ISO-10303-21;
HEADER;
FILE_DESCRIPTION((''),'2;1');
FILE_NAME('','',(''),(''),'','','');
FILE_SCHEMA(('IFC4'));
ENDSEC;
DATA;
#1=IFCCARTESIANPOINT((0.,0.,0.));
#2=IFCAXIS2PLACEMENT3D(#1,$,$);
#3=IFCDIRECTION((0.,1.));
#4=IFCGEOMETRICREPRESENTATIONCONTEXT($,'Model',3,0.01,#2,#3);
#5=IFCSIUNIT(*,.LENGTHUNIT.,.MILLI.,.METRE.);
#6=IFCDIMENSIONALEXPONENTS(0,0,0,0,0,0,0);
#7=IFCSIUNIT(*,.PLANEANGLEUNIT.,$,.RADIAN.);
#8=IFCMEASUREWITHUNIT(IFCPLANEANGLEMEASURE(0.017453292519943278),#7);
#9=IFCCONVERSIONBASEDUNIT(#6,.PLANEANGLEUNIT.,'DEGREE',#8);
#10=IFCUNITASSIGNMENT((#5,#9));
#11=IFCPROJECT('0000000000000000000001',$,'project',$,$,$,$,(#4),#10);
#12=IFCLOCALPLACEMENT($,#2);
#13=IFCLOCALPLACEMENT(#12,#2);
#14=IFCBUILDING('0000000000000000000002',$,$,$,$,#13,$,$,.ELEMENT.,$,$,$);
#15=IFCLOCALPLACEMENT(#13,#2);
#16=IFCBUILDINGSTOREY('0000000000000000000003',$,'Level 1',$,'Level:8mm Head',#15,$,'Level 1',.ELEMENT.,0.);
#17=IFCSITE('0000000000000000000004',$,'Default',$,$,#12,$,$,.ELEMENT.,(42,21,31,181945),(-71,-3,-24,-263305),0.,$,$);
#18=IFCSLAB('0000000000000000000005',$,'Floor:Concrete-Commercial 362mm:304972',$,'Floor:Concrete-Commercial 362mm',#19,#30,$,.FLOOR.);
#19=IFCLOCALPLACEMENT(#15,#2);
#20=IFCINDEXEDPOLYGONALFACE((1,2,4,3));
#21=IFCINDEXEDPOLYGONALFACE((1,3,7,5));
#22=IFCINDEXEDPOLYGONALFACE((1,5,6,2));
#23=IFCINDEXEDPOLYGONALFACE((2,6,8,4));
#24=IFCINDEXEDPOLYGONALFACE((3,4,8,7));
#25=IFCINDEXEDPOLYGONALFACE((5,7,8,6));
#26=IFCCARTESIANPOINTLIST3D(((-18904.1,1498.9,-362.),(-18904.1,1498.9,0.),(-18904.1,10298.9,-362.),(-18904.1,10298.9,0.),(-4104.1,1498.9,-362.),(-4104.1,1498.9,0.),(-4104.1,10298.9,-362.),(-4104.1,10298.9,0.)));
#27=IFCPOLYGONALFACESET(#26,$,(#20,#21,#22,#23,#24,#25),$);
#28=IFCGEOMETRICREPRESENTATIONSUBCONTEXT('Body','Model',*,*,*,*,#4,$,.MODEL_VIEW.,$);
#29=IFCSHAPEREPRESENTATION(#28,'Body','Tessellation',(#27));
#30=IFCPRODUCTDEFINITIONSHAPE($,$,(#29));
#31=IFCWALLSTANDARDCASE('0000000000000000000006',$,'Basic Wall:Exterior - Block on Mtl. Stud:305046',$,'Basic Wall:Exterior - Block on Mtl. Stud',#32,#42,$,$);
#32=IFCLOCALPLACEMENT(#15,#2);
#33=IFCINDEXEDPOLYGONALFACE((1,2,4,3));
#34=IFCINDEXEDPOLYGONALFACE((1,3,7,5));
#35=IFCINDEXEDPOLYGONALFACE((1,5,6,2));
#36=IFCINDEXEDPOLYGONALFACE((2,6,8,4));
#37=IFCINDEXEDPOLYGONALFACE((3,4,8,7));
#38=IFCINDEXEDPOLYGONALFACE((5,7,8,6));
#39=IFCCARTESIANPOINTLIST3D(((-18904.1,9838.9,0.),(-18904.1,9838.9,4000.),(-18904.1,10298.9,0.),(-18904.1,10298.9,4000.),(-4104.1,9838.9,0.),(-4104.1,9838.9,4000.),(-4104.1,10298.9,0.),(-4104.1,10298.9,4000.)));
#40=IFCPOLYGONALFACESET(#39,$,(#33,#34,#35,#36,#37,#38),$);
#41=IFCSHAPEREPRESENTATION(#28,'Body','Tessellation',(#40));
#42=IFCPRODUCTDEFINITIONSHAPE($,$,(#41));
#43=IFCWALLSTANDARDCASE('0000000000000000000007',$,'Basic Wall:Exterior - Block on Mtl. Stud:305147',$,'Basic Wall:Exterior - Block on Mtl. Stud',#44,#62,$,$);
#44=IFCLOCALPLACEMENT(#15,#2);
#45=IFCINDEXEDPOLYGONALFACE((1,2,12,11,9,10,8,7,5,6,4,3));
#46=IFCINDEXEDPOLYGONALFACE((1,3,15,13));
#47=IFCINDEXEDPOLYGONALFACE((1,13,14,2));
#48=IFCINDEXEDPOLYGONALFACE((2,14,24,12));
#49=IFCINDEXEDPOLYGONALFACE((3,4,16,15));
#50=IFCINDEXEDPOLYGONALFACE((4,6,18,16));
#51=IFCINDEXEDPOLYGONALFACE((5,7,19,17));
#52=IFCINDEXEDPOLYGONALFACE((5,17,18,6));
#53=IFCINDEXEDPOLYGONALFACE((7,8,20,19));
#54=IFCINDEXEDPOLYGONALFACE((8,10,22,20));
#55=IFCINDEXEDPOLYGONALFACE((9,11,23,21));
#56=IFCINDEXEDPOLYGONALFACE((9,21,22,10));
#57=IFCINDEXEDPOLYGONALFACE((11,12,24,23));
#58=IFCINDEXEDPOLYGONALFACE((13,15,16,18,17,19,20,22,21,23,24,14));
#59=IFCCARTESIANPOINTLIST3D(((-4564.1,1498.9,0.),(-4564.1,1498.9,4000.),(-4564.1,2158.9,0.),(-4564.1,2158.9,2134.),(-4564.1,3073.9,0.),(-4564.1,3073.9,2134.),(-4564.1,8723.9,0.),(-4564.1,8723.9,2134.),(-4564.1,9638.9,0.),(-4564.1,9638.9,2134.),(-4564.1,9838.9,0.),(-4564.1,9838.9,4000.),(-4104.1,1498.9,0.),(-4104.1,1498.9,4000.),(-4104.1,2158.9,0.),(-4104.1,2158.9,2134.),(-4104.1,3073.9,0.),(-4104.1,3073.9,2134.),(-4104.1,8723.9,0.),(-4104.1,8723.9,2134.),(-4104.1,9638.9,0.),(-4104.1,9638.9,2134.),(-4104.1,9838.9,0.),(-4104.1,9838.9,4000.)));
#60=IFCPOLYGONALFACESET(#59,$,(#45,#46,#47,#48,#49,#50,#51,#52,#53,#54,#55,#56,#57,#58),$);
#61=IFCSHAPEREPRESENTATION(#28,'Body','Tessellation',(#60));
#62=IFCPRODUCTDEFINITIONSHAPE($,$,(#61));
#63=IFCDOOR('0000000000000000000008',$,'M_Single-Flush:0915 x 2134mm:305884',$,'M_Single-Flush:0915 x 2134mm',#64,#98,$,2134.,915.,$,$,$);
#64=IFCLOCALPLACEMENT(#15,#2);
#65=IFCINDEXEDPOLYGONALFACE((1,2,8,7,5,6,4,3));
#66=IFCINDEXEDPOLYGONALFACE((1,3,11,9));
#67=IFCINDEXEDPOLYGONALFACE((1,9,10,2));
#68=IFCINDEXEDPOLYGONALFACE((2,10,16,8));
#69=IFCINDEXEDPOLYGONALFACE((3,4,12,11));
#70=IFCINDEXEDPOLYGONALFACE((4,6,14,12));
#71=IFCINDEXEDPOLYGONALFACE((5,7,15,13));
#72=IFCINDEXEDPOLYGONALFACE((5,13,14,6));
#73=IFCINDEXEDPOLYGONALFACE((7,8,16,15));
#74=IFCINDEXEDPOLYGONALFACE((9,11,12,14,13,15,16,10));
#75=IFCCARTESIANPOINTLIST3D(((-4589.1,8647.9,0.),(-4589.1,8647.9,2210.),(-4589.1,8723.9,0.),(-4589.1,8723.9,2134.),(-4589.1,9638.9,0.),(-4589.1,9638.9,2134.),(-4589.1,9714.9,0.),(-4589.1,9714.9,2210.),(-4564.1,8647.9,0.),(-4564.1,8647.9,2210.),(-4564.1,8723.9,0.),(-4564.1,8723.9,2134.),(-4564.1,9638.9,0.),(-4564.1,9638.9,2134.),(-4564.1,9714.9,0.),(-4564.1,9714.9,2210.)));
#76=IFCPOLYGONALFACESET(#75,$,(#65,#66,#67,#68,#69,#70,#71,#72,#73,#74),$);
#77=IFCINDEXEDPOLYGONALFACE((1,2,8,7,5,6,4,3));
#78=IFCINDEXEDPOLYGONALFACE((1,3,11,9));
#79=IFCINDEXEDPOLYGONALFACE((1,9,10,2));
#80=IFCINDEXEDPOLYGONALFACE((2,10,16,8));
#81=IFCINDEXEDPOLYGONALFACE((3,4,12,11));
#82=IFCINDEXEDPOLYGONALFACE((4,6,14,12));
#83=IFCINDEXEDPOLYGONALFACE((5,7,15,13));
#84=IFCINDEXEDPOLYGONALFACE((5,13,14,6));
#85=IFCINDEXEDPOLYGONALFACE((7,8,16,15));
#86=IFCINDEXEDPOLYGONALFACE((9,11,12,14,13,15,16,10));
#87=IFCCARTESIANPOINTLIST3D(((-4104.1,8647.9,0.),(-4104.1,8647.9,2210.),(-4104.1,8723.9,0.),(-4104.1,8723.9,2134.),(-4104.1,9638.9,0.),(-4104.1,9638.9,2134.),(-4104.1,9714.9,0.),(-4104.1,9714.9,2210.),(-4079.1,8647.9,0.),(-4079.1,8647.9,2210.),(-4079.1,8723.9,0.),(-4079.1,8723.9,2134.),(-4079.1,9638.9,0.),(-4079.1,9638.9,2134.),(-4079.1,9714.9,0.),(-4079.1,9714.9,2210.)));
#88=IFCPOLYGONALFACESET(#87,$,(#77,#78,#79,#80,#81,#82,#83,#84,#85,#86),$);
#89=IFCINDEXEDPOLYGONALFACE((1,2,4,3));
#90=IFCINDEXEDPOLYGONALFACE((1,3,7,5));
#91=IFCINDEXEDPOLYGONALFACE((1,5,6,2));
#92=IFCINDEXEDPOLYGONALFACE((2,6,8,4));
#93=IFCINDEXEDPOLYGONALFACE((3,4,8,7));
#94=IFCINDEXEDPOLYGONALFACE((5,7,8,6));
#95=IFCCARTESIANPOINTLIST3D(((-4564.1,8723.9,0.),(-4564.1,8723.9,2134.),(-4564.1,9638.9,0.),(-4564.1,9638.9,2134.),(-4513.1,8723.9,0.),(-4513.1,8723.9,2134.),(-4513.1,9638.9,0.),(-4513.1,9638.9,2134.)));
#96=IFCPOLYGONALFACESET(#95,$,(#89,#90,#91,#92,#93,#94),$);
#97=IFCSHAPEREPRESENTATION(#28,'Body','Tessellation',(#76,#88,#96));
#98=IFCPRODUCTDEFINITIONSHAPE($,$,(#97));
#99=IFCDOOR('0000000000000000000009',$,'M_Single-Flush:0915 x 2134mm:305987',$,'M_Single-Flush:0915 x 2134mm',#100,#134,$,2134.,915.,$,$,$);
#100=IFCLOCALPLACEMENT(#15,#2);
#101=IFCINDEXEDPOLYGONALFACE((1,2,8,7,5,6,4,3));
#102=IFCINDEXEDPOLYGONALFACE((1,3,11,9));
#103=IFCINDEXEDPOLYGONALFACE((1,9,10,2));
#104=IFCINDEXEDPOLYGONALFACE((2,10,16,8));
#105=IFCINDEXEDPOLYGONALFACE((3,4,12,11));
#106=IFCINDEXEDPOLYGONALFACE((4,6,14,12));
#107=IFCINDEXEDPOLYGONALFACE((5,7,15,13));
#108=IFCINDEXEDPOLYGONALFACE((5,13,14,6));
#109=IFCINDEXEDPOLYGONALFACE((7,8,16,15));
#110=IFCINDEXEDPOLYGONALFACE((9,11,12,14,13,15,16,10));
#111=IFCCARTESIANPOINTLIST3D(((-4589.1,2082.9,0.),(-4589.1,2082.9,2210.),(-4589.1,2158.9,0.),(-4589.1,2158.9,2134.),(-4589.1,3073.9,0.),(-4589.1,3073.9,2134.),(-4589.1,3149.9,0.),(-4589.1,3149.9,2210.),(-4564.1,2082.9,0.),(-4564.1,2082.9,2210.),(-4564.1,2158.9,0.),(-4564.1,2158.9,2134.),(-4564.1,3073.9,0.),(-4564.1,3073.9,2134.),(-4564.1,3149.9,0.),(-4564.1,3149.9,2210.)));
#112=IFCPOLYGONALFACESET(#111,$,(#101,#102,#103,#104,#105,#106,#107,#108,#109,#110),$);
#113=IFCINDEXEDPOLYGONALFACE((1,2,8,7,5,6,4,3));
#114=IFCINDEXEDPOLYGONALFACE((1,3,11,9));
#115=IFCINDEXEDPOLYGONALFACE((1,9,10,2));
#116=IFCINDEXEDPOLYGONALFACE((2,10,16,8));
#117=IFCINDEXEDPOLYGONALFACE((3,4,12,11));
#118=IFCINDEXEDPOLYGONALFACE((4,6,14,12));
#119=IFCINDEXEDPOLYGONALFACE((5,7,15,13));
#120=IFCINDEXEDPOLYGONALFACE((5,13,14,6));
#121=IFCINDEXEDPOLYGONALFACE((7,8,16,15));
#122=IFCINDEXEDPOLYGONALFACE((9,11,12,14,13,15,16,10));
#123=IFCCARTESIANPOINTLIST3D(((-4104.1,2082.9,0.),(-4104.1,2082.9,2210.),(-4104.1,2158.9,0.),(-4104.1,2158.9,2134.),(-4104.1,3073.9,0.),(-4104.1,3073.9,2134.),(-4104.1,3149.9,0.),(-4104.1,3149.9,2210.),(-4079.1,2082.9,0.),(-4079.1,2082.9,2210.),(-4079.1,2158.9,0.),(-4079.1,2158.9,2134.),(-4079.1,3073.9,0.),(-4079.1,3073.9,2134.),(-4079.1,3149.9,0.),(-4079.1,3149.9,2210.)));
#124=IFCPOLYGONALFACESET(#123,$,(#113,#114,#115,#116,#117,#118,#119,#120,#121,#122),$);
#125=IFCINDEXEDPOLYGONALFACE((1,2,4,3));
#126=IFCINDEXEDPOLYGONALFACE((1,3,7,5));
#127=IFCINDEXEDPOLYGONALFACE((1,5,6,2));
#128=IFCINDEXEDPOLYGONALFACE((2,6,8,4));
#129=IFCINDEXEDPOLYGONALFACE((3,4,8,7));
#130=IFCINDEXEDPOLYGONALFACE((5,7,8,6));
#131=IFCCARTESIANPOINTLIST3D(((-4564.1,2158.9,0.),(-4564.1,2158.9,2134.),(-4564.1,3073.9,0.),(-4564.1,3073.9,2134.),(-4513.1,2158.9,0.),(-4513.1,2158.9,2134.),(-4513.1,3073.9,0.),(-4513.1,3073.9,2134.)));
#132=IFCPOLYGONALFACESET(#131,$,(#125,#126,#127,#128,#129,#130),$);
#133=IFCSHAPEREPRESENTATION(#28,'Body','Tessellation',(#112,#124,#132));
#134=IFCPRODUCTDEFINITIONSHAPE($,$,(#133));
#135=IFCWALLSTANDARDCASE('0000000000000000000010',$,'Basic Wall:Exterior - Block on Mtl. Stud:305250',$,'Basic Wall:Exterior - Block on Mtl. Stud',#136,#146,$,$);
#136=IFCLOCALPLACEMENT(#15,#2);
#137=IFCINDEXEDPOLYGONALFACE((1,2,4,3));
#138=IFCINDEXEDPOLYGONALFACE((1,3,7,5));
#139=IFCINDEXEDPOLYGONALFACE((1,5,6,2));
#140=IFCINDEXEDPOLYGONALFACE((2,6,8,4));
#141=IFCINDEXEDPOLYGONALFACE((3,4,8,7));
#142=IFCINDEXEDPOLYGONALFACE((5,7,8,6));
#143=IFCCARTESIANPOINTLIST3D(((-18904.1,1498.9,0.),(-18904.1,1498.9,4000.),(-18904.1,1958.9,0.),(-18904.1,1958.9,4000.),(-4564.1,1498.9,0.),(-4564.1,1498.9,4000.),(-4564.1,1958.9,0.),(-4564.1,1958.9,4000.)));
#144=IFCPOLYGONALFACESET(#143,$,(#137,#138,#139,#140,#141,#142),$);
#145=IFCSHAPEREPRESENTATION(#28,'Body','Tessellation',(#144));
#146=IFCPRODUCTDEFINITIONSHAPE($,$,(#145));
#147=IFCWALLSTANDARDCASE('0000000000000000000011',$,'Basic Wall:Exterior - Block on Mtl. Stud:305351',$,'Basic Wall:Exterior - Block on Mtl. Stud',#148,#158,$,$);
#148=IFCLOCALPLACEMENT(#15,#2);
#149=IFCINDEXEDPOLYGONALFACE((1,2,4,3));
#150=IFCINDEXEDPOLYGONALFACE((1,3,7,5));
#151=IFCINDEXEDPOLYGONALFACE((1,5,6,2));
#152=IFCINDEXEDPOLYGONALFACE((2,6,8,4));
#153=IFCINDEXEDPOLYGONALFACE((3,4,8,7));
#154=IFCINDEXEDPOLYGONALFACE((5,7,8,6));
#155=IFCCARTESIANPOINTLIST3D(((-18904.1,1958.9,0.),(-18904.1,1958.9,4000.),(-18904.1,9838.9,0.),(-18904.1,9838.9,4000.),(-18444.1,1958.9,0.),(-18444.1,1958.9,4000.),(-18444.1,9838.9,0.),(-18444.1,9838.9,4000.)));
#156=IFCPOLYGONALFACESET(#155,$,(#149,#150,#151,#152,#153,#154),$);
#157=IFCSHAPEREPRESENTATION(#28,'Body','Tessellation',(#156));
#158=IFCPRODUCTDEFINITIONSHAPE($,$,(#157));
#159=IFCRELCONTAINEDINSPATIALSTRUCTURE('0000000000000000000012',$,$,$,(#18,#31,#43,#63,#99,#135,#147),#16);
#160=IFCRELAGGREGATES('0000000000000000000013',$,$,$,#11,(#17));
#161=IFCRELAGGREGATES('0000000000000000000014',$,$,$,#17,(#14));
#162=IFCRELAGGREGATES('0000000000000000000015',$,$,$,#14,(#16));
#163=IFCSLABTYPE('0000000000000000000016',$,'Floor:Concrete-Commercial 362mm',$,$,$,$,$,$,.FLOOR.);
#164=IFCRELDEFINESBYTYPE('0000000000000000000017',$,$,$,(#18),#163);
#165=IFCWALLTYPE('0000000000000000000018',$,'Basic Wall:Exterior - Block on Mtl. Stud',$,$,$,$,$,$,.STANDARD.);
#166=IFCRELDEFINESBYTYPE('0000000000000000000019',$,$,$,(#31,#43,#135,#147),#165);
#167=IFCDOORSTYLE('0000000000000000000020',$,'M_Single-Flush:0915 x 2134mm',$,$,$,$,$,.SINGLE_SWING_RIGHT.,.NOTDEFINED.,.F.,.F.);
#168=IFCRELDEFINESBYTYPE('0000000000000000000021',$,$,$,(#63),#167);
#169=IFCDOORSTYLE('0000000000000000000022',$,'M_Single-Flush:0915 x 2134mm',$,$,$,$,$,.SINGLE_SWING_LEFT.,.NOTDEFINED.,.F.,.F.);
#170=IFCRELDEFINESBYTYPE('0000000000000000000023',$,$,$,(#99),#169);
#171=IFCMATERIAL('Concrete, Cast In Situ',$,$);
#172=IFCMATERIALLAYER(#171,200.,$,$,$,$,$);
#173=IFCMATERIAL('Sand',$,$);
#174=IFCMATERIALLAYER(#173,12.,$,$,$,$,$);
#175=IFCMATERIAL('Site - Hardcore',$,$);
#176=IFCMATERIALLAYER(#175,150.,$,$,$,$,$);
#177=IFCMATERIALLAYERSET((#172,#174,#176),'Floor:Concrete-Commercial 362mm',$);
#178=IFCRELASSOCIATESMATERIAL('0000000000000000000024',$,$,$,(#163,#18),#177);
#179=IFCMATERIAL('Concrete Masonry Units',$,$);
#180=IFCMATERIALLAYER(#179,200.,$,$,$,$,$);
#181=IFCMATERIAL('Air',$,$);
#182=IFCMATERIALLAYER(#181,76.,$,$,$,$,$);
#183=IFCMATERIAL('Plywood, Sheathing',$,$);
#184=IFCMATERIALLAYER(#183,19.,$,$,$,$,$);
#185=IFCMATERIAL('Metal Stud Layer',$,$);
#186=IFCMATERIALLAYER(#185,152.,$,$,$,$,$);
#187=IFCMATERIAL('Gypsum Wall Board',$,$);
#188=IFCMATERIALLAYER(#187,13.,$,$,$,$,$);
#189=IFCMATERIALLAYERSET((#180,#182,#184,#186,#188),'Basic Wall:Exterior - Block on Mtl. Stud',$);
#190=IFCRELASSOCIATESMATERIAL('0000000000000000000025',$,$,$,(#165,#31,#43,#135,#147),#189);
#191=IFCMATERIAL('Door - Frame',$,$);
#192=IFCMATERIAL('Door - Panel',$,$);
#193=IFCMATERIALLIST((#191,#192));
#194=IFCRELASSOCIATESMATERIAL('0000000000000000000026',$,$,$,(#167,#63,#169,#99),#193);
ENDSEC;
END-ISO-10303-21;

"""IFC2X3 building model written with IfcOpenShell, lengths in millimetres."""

from ifc_helpers import new_model, entity, si_unit, converted_unit, direction, frame, frame_2d, origin, place, context, subcontext, project, spatial, polyline, rectangle, outline, extrude, source, transform, mapped, material, material_list, layer, layer_set, layer_usage, type_object, type_shapes, element, fill, save


model = new_model("IFC2X3")

# Units and contexts
model_context = context("Model", 3, precision=0.01, world=origin(), true_north=direction((0.0, 1.0)))
body_context = subcontext(model_context, "Body", "Model", "MODEL_VIEW")
ifc_project = project(units=[si_unit("LENGTHUNIT", "METRE", prefix="MILLI"), converted_unit("PLANEANGLEUNIT", "DEGREE", entity("IfcPlaneAngleMeasure", 0.017453292519943278), si_unit("PLANEANGLEUNIT", "RADIAN"), dimensions=[0, 0, 0, 0, 0, 0, 0])], contexts=[model_context])

# Site, building, storey
site_placement = place(None, origin())
site = spatial("IfcSite", under=ifc_project, at=site_placement, Name="Default", CompositionType="ELEMENT", RefLatitude=(42, 21, 31, 181945), RefLongitude=(-71, -3, -24, -263305), RefElevation=0.0)
building_placement = place(site_placement, origin())
building = spatial("IfcBuilding", under=site, at=building_placement, CompositionType="ELEMENT")
storey_placement = place(building_placement, origin())
storey = spatial("IfcBuildingStorey", under=building, at=storey_placement, Name="Level 1", ObjectType="Level:8mm Head", LongName="Level 1", CompositionType="ELEMENT", Elevation=0.0)

# Slab
ifc_material_1 = material(Name="Concrete, Cast In Situ")
ifc_layer_1 = layer(ifc_material_1, 200.0)
ifc_material_2 = material(Name="Sand")
ifc_layer_2 = layer(ifc_material_2, 12.0)
ifc_material_3 = material(Name="Site - Hardcore")
ifc_layer_3 = layer(ifc_material_3, 150.0)
ifc_layer_set_1 = layer_set([ifc_layer_1, ifc_layer_2, ifc_layer_3], Name="Floor:Concrete-Commercial 362mm")
ifc_layer_usage_1 = layer_usage(ifc_layer_set_1, "AXIS3", "POSITIVE", 0.0)
slab_type = type_object("IfcSlabType", Name="Floor:Concrete-Commercial 362mm", PredefinedType="FLOOR", material=ifc_layer_set_1)
slab_placement = place(storey_placement, origin())
element("IfcSlab", 1, at=slab_placement, inside=storey, type_object=slab_type, material=ifc_layer_usage_1, Name="Floor:Concrete-Commercial 362mm:304972", ObjectType="Floor:Concrete-Commercial 362mm", PredefinedType="FLOOR", context=body_context, shape_type="SweptSolid", body=[
    extrude(rectangle(XDim=8800.0, YDim=14800.0, at=frame_2d((0.0, 0.0), x_axis=(1.0, 0.0))), frame((-11504.1, 5898.9, 0.0), z_axis=(0.0, 0.0, -1.0), x_axis=(0.0, 1.0, 0.0)), (0.0, 0.0, 1.0), 362.0),
])

# Wall
ifc_material_4 = material(Name="Concrete Masonry Units")
ifc_layer_4 = layer(ifc_material_4, 200.0)
ifc_material_5 = material(Name="Air")
ifc_layer_5 = layer(ifc_material_5, 76.0)
ifc_material_6 = material(Name="Plywood, Sheathing")
ifc_layer_6 = layer(ifc_material_6, 19.0)
ifc_material_7 = material(Name="Metal Stud Layer")
ifc_layer_7 = layer(ifc_material_7, 152.0)
ifc_material_8 = material(Name="Gypsum Wall Board")
ifc_layer_8 = layer(ifc_material_8, 13.0)
ifc_layer_set_2 = layer_set([ifc_layer_4, ifc_layer_5, ifc_layer_6, ifc_layer_7, ifc_layer_8], Name="Basic Wall:Exterior - Block on Mtl. Stud")
ifc_layer_usage_2 = layer_usage(ifc_layer_set_2, "AXIS2", "NEGATIVE", 230.0)
wall_type_1 = type_object("IfcWallType", Name="Basic Wall:Exterior - Block on Mtl. Stud", PredefinedType="STANDARD", material=ifc_layer_set_2)
wall_1_placement = place(storey_placement, frame((-18904.1, 10068.9, 0.0)))
element("IfcWallStandardCase", 2, at=wall_1_placement, inside=storey, type_object=wall_type_1, material=ifc_layer_usage_2, Name="Basic Wall:Exterior - Block on Mtl. Stud:305046", ObjectType="Basic Wall:Exterior - Block on Mtl. Stud", context=body_context, shape_type="SweptSolid", body=[
    extrude(rectangle(XDim=14800.0, YDim=460.0, at=frame_2d((7400.0, 0.0), x_axis=(-1.0, 0.0))), origin(), (0.0, 0.0, 1.0), 4000.0),
])

# Wall, openings, doors
wall_2_placement = place(storey_placement, frame((-4334.1, 9838.9, 0.0), z_axis=(0.0, 0.0, 1.0), x_axis=(0.0, -1.0, 0.0)))
wall_2 = element("IfcWallStandardCase", 3, at=wall_2_placement, inside=storey, type_object=wall_type_1, material=ifc_layer_usage_2, Name="Basic Wall:Exterior - Block on Mtl. Stud:305147", ObjectType="Basic Wall:Exterior - Block on Mtl. Stud", context=body_context, shape_type="SweptSolid", body=[
    extrude(rectangle(XDim=8340.0, YDim=460.0, at=frame_2d((4170.0, 0.0), x_axis=(-1.0, 0.0))), origin(), (0.0, 0.0, 1.0), 4000.0),
])
opening_1_placement = place(wall_2_placement, frame((1115.0, 230.0, 0.0)))
opening_1 = element("IfcOpeningElement", 4, at=opening_1_placement, cuts=wall_2, ObjectType="Opening", context=body_context, shape_type="SweptSolid", body=[
    extrude(rectangle(XDim=915.0, YDim=2134.0, at=frame_2d((1067.0, 457.5), x_axis=(0.0, 1.0))), frame((0.0, 0.0, 0.0), z_axis=(0.0, -1.0, 0.0), x_axis=(0.0, 0.0, 1.0)), (0.0, 0.0, 1.0), 460.0),
])
opening_2_placement = place(wall_2_placement, frame((7680.0, 230.0, 0.0)))
opening_2 = element("IfcOpeningElement", 5, at=opening_2_placement, cuts=wall_2, ObjectType="Opening", context=body_context, shape_type="SweptSolid", body=[
    extrude(rectangle(XDim=915.0, YDim=2134.0, at=frame_2d((1067.0, 457.5), x_axis=(0.0, -1.0))), frame((0.0, 0.0, 0.0), z_axis=(0.0, -1.0, 0.0), x_axis=(0.0, 0.0, 1.0)), (0.0, 0.0, 1.0), 460.0),
])
ifc_material_9 = material(Name="Door - Frame")
ifc_material_10 = material(Name="Door - Panel")
ifc_material_list = material_list([ifc_material_9, ifc_material_10])
door_style_1 = type_object("IfcDoorStyle", Name="M_Single-Flush:0915 x 2134mm", ConstructionType="NOTDEFINED", OperationType="SINGLE_SWING_RIGHT", ParameterTakesPrecedence=False, Sizeable=False, material=ifc_material_list)
shared_shape_1 = source(origin(), body_context, "Body", "SweptSolid", [
    extrude(outline(polyline([(-533.5, -1124.0), (533.5, -1124.0), (533.5, 1086.0), (457.5, 1086.0), (457.5, -1048.0), (-457.5, -1048.0), (-457.5, 1086.0), (-533.5, 1086.0), (-533.5, -1124.0)])), frame((457.5, 460.0, 1086.0), z_axis=(0.0, 1.0, 0.0), x_axis=(1.0, 0.0, 0.0)), (0.0, 0.0, 1.0), 25.0),
    extrude(outline(polyline([(-1124.0, -533.5), (1086.0, -533.5), (1086.0, -457.5), (-1048.0, -457.5), (-1048.0, 457.5), (1086.0, 457.5), (1086.0, 533.5), (-1124.0, 533.5), (-1124.0, -533.5)])), frame((457.5, -25.0, 1086.0), z_axis=(0.0, 1.0, 0.0), x_axis=(0.0, 0.0, -1.0)), (0.0, 0.0, 1.0), 25.0),
    extrude(rectangle(XDim=51.0, YDim=915.0, at=frame_2d((0.0, 0.0), x_axis=(1.0, 0.0))), frame((457.5, 434.5, 0.0), z_axis=(0.0, 0.0, 1.0), x_axis=(0.0, 1.0, 0.0)), (0.0, 0.0, 1.0), 2134.0),
])
type_shapes(door_style_1, [shared_shape_1])
door_1_placement = place(opening_1_placement, frame((0.0, 0.0, 0.0), z_axis=(0.0, 0.0, 1.0), x_axis=(-1.0, 0.0, 0.0)))
door_1 = element("IfcDoor", 6, at=door_1_placement, inside=storey, type_object=door_style_1, material=ifc_material_list, Name="M_Single-Flush:0915 x 2134mm:305884", ObjectType="M_Single-Flush:0915 x 2134mm", OverallHeight=2134.0, OverallWidth=915.0, context=body_context, shape_type="MappedRepresentation", body=[
    mapped(shared_shape_1, transform((0.0, 0.0, 0.0), scale=1.0)),
])
fill(opening_1, door_1)
door_style_2 = type_object("IfcDoorStyle", Name="M_Single-Flush:0915 x 2134mm", ConstructionType="NOTDEFINED", OperationType="SINGLE_SWING_LEFT", ParameterTakesPrecedence=False, Sizeable=False, material=ifc_material_list)
shared_shape_2 = source(origin(), body_context, "Body", "SweptSolid", [
    extrude(outline(polyline([(-533.5, -1124.0), (533.5, -1124.0), (533.5, 1086.0), (457.5, 1086.0), (457.5, -1048.0), (-457.5, -1048.0), (-457.5, 1086.0), (-533.5, 1086.0), (-533.5, -1124.0)])), frame((457.5, 485.0, 1086.0), z_axis=(0.0, -1.0, 0.0), x_axis=(-1.0, 0.0, 0.0)), (0.0, 0.0, 1.0), 25.0),
    extrude(outline(polyline([(-1124.0, -533.5), (1086.0, -533.5), (1086.0, -457.5), (-1048.0, -457.5), (-1048.0, 457.5), (1086.0, 457.5), (1086.0, 533.5), (-1124.0, 533.5), (-1124.0, -533.5)])), frame((457.5, 0.0, 1086.0), z_axis=(0.0, -1.0, 0.0), x_axis=(0.0, 0.0, -1.0)), (0.0, 0.0, 1.0), 25.0),
    extrude(rectangle(XDim=915.0, YDim=51.0, at=frame_2d((0.0, 0.0), x_axis=(1.0, 0.0))), frame((457.5, 434.5, 0.0)), (0.0, 0.0, 1.0), 2134.0),
])
type_shapes(door_style_2, [shared_shape_2])
door_2_placement = place(opening_2_placement, frame((0.0, 0.0, 0.0), z_axis=(0.0, 0.0, 1.0), x_axis=(-1.0, 0.0, 0.0)))
door_2 = element("IfcDoor", 7, at=door_2_placement, inside=storey, type_object=door_style_2, material=ifc_material_list, Name="M_Single-Flush:0915 x 2134mm:305987", ObjectType="M_Single-Flush:0915 x 2134mm", OverallHeight=2134.0, OverallWidth=915.0, context=body_context, shape_type="MappedRepresentation", body=[
    mapped(shared_shape_2, transform((0.0, 0.0, 0.0), scale=1.0)),
])
fill(opening_2, door_2)

# Walls
wall_3_placement = place(storey_placement, frame((-4564.1, 1728.9, 0.0), z_axis=(0.0, 0.0, 1.0), x_axis=(-1.0, 0.0, 0.0)))
element("IfcWallStandardCase", 8, at=wall_3_placement, inside=storey, type_object=wall_type_1, material=ifc_layer_usage_2, Name="Basic Wall:Exterior - Block on Mtl. Stud:305250", ObjectType="Basic Wall:Exterior - Block on Mtl. Stud", context=body_context, shape_type="SweptSolid", body=[
    extrude(rectangle(XDim=14340.0, YDim=460.0, at=frame_2d((7170.0, 0.0), x_axis=(-1.0, 0.0))), origin(), (0.0, 0.0, 1.0), 4000.0),
])
wall_4_placement = place(storey_placement, frame((-18674.1, 1958.9, 0.0), z_axis=(0.0, 0.0, 1.0), x_axis=(0.0, 1.0, 0.0)))
element("IfcWallStandardCase", 9, at=wall_4_placement, inside=storey, type_object=wall_type_1, material=ifc_layer_usage_2, Name="Basic Wall:Exterior - Block on Mtl. Stud:305351", ObjectType="Basic Wall:Exterior - Block on Mtl. Stud", context=body_context, shape_type="SweptSolid", body=[
    extrude(rectangle(XDim=7880.0, YDim=460.0, at=frame_2d((3940.0, 0.0), x_axis=(-1.0, 0.0))), origin(), (0.0, 0.0, 1.0), 4000.0),
])

save(model, "model.ifc")
